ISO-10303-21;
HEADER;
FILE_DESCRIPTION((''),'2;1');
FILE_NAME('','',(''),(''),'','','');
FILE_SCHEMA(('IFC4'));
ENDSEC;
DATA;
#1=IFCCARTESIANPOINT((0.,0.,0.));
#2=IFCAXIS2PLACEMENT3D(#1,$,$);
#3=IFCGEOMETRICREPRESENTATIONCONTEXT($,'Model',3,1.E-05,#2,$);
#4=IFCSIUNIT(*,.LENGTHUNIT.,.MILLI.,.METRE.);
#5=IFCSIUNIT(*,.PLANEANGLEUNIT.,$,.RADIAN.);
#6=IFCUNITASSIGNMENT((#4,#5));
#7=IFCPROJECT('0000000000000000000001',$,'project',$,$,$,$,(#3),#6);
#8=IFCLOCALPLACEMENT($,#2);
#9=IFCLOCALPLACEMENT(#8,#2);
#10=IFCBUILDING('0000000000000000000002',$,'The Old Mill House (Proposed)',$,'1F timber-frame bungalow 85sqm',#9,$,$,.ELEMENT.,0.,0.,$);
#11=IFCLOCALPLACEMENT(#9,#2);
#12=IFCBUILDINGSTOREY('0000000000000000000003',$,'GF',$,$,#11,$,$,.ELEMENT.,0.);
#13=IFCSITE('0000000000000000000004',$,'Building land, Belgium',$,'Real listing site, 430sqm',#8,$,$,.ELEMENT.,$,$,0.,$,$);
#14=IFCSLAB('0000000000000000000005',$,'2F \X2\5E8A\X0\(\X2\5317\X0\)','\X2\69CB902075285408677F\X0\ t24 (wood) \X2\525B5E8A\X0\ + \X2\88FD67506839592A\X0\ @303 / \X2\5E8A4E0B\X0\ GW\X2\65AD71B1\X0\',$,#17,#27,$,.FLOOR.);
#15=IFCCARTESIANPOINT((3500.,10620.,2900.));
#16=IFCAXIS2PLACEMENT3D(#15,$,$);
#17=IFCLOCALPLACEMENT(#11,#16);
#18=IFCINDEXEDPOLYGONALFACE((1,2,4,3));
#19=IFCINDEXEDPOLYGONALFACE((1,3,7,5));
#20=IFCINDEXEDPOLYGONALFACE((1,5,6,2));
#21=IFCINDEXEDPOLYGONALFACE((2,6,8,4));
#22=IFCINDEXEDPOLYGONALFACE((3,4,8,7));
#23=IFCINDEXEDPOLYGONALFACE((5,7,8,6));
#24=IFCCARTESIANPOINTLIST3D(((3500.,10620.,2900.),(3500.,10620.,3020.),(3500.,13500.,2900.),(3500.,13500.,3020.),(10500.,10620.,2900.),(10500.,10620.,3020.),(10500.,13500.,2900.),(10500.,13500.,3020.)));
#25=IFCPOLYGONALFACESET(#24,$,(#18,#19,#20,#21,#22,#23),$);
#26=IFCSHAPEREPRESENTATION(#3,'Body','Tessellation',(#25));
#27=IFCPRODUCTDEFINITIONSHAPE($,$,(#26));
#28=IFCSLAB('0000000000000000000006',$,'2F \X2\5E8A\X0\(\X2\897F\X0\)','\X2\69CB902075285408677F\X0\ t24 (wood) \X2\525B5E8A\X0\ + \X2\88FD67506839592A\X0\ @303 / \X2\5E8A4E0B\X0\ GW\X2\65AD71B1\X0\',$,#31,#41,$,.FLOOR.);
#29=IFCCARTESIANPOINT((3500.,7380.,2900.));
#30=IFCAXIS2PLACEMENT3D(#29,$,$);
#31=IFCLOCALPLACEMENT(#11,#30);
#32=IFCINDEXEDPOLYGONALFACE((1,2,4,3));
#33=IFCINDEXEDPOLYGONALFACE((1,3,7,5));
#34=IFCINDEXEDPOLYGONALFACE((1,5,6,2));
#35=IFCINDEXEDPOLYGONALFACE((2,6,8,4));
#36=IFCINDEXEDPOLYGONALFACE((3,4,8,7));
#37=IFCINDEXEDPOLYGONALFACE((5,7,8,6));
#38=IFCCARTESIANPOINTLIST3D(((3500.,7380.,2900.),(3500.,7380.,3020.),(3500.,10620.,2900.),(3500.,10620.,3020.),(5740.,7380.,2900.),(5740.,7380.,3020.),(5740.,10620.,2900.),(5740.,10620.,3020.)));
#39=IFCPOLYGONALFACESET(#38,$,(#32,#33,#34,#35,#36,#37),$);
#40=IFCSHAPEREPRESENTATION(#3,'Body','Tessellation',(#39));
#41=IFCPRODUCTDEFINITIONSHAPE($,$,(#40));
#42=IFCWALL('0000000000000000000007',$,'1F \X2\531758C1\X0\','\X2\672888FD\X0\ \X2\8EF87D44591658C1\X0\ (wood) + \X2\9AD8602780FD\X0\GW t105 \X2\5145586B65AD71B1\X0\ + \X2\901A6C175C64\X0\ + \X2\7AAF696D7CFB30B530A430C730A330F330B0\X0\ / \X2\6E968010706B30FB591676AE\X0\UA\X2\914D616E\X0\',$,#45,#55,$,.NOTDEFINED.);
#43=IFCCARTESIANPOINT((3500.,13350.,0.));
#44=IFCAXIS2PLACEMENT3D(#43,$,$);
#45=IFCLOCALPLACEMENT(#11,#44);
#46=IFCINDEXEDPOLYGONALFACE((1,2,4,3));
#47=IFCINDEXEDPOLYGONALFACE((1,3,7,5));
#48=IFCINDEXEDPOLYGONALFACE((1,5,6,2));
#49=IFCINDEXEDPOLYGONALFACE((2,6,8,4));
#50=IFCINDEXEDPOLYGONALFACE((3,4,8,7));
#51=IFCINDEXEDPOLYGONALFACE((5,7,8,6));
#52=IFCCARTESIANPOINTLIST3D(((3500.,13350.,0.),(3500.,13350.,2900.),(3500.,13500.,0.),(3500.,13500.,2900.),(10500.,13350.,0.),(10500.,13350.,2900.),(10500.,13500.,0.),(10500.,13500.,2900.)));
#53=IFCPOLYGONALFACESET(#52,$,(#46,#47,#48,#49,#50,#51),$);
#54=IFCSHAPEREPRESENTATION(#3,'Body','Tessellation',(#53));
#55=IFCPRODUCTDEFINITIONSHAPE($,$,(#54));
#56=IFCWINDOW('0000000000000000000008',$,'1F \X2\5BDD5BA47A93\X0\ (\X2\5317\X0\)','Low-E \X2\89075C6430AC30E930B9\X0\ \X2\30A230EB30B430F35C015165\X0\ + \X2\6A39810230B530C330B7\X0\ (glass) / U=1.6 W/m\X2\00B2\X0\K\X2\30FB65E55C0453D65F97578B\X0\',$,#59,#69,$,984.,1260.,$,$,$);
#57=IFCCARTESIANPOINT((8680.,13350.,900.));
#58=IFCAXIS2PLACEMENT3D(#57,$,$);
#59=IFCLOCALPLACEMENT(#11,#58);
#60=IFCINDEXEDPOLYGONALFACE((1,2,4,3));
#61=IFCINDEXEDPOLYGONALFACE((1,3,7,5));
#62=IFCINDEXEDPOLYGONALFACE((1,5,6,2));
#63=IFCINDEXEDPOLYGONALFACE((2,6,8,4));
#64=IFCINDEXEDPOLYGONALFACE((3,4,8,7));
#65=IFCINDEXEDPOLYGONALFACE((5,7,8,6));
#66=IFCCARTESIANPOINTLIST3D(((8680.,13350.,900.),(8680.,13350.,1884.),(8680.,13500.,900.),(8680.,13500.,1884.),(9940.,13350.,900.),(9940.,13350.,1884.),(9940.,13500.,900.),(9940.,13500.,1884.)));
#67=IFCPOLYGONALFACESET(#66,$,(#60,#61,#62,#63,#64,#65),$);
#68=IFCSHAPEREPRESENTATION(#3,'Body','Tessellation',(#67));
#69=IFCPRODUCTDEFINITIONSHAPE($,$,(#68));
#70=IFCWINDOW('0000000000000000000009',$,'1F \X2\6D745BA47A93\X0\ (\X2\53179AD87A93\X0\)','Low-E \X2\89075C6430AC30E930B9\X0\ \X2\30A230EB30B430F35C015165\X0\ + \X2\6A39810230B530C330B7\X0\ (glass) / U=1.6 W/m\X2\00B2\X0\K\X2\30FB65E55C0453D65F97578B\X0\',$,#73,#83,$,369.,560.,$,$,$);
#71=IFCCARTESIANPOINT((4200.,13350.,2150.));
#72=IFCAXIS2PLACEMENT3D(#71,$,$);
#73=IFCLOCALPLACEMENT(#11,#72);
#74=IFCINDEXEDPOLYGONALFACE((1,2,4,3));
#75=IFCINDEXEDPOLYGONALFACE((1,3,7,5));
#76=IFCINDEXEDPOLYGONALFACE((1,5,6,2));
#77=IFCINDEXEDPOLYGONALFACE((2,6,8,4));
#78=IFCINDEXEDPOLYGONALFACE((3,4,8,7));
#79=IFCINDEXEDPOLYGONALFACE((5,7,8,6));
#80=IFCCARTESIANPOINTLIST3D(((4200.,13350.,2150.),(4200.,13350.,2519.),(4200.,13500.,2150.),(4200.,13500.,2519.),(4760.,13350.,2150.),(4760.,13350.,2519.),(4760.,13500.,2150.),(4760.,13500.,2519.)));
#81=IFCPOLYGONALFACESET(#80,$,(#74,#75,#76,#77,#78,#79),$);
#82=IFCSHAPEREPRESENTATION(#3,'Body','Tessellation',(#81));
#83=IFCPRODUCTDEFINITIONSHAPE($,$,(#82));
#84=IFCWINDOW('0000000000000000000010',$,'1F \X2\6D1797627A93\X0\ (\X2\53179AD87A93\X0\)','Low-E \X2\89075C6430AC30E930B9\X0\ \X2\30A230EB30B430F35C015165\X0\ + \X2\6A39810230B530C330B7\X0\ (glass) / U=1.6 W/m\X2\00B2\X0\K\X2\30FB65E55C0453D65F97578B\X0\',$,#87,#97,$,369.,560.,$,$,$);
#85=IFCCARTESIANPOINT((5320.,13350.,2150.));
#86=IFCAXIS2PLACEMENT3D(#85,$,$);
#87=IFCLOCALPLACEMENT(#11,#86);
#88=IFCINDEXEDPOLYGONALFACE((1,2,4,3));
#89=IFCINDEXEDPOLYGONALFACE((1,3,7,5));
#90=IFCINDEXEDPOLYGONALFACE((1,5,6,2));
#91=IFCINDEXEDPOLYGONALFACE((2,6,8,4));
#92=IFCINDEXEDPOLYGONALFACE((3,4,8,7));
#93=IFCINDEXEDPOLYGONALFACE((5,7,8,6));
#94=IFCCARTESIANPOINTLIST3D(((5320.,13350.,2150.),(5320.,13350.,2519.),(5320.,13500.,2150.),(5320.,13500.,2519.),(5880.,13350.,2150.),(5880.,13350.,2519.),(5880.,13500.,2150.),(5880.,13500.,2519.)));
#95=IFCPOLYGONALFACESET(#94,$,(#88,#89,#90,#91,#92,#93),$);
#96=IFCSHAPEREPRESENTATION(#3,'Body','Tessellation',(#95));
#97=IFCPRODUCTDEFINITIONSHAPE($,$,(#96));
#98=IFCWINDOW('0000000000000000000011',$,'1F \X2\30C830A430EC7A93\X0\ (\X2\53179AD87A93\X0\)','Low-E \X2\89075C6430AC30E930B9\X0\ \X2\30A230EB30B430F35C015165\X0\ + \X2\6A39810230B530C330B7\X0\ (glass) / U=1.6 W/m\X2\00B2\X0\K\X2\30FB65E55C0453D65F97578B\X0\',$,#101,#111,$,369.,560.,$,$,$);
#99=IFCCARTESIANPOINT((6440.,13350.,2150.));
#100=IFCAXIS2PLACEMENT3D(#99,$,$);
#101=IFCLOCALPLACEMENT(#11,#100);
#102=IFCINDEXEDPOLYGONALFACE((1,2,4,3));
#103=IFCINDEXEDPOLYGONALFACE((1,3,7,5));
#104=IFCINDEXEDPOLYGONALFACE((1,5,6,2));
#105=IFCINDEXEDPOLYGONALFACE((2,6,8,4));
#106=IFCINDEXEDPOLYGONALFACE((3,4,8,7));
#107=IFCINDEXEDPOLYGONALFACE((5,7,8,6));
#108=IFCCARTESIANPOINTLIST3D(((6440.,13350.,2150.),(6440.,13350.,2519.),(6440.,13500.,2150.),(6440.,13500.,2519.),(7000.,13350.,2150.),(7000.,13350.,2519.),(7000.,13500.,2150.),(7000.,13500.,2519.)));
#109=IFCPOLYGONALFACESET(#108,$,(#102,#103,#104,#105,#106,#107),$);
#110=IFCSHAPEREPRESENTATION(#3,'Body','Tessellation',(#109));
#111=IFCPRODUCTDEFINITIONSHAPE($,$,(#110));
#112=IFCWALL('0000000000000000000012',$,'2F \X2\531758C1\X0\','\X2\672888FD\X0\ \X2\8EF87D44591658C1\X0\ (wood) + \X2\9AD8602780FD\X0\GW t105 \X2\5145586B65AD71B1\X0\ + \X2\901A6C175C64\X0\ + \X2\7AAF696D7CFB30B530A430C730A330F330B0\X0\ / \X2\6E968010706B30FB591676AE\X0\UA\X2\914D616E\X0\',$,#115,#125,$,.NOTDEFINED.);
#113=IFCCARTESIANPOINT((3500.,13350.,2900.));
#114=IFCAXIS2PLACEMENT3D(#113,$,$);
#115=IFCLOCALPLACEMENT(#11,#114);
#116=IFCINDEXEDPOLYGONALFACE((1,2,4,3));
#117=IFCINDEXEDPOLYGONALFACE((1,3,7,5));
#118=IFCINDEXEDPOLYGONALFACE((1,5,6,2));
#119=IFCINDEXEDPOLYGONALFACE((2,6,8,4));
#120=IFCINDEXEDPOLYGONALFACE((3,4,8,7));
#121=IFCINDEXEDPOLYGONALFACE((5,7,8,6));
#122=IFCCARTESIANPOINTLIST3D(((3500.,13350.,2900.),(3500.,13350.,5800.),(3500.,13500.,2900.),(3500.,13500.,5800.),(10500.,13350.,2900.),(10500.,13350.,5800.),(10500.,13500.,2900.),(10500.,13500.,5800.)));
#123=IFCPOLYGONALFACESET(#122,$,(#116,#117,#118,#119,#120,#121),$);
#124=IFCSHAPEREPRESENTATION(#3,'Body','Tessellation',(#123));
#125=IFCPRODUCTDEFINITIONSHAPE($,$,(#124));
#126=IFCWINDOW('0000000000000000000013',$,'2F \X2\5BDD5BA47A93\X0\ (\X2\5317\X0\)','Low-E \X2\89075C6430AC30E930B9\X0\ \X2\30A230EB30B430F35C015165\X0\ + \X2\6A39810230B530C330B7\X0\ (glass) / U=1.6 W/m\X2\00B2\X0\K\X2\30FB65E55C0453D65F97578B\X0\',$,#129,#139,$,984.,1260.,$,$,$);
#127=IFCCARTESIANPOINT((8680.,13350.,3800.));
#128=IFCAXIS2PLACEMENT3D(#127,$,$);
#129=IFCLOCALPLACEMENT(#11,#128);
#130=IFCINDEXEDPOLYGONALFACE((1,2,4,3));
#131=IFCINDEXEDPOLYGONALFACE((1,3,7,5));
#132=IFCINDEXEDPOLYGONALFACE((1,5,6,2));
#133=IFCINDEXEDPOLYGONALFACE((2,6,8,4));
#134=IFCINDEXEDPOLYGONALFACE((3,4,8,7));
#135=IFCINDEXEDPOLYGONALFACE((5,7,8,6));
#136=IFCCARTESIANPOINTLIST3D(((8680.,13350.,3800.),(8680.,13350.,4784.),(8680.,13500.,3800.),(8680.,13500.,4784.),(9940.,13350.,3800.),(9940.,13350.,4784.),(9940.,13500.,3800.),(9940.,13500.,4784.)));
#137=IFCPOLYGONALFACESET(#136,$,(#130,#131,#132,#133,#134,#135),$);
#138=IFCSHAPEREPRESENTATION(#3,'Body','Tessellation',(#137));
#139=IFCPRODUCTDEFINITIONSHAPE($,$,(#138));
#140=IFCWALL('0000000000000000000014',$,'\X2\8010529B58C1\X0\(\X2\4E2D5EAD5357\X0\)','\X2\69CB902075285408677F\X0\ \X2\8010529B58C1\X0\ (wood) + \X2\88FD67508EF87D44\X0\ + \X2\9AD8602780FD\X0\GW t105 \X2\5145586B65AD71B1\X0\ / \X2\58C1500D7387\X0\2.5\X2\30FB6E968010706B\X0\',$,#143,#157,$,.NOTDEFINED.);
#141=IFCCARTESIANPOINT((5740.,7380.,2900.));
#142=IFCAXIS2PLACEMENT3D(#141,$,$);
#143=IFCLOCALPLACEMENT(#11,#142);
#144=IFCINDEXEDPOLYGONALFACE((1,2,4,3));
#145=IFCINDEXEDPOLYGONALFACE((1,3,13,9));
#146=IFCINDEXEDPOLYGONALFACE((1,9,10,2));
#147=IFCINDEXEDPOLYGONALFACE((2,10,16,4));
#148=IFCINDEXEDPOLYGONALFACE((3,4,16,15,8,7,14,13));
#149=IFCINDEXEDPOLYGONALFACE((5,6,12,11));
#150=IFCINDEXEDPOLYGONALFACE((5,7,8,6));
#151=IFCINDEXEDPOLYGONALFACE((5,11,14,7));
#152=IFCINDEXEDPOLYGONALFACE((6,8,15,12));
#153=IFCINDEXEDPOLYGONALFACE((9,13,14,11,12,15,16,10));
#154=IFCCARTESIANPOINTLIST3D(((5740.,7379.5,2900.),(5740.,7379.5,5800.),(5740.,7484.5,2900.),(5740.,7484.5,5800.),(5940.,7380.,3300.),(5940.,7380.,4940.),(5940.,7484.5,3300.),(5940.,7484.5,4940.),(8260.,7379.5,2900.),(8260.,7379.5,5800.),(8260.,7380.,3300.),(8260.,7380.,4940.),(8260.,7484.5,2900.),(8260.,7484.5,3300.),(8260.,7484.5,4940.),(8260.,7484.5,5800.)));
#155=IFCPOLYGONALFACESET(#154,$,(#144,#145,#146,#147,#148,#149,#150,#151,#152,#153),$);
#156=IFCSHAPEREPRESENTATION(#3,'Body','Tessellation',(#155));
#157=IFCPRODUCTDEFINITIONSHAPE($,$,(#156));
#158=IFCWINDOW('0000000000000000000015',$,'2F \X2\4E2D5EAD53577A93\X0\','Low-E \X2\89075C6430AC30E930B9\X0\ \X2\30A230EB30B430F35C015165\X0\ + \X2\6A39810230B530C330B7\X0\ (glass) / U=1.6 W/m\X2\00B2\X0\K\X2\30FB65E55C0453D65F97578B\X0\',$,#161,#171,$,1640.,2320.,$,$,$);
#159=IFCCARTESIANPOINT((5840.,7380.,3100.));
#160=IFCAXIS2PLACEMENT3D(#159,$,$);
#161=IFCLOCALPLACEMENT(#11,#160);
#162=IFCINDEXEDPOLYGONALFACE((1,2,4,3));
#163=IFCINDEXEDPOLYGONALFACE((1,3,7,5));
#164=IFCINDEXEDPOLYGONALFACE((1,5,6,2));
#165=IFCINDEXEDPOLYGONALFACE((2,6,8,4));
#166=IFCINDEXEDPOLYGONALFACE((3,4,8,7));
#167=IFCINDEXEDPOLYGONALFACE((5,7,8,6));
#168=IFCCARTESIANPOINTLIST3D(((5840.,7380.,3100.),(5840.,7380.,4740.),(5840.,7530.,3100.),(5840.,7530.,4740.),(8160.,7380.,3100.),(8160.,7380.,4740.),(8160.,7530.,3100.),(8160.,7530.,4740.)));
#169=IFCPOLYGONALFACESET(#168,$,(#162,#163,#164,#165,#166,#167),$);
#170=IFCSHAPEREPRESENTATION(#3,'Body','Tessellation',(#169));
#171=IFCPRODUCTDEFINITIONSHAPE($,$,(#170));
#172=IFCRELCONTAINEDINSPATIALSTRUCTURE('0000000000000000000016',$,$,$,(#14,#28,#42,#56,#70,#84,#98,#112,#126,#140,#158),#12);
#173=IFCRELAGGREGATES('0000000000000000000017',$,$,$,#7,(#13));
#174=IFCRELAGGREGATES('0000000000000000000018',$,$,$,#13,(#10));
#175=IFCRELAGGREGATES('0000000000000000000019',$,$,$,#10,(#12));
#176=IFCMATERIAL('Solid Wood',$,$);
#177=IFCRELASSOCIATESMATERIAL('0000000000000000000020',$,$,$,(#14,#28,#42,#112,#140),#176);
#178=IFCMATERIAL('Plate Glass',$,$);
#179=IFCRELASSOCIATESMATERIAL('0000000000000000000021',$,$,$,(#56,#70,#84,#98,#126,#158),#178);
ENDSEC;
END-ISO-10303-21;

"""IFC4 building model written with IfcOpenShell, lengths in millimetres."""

from ifc_helpers import new_model, si_unit, frame, frame_2d, origin, place, context, project, spatial, rectangle, extrude, material, element, fill, save


model = new_model("IFC4")

# Units and contexts
model_context = context("Model", 3, precision=1e-05, world=origin())
ifc_project = project(units=[si_unit("LENGTHUNIT", "METRE", prefix="MILLI"), si_unit("PLANEANGLEUNIT", "RADIAN")], contexts=[model_context])

# Site, building, storey
site_placement = place(None, origin())
site = spatial("IfcSite", under=ifc_project, at=site_placement, Name="Building land, Belgium", ObjectType="Real listing site, 430sqm", CompositionType="ELEMENT", RefElevation=0.0)
building_placement = place(site_placement, origin())
building = spatial("IfcBuilding", under=site, at=building_placement, Name="The Old Mill House (Proposed)", ObjectType="1F timber-frame bungalow 85sqm", CompositionType="ELEMENT", ElevationOfRefHeight=0.0, ElevationOfTerrain=0.0)
storey_placement = place(building_placement, origin())
storey = spatial("IfcBuildingStorey", under=building, at=storey_placement, Name="GF", CompositionType="ELEMENT", Elevation=0.0)

# Slabs
ifc_material_1 = material(Name="Solid Wood")
slab_1_placement = place(storey_placement, frame((3500.0, 10620.0, 2900.0)))
element("IfcSlab", 1, at=slab_1_placement, inside=storey, material=ifc_material_1, Name="2F 床(北)", Description="構造用合板 t24 (wood) 剛床 + 製材根太 @303 / 床下 GW断熱", PredefinedType="FLOOR", context=model_context, shape_type="SweptSolid", body=[
    extrude(rectangle(XDim=7000.0, YDim=2880.0, at=frame_2d((3500.0, 1440.0))), frame((3500.0, 10620.0, 2900.0)), (0.0, 0.0, 1.0), 120.0),
])
slab_2_placement = place(storey_placement, frame((3500.0, 7380.0, 2900.0)))
element("IfcSlab", 2, at=slab_2_placement, inside=storey, material=ifc_material_1, Name="2F 床(西)", Description="構造用合板 t24 (wood) 剛床 + 製材根太 @303 / 床下 GW断熱", PredefinedType="FLOOR", context=model_context, shape_type="SweptSolid", body=[
    extrude(rectangle(XDim=2240.0, YDim=3240.0, at=frame_2d((1120.0, 1620.0))), frame((3500.0, 7380.0, 2900.0)), (0.0, 0.0, 1.0), 120.0),
])

# Wall, openings, windows
wall_1_placement = place(storey_placement, frame((3500.0, 13350.0, 0.0)))
wall_1 = element("IfcWall", 3, at=wall_1_placement, inside=storey, material=ifc_material_1, Name="1F 北壁", Description="木製 軸組外壁 (wood) + 高性能GW t105 充填断熱 + 通気層 + 窯業系サイディング / 準耐火・外皮UA配慮", PredefinedType="NOTDEFINED", context=model_context, shape_type="SweptSolid", body=[
    extrude(rectangle(XDim=7000.0, YDim=150.0, at=frame_2d((3500.0, 75.0))), frame((3500.0, 13350.0, 0.0)), (0.0, 0.0, 1.0), 2900.0),
])
opening_1_placement = place(storey_placement, frame((8680.0, 13350.0, 900.0)))
opening_1 = element("IfcOpeningElement", 4, at=opening_1_placement, cuts=wall_1, PredefinedType="NOTDEFINED", context=model_context, shape_type="SweptSolid", body=[
    extrude(rectangle(XDim=1260.0, YDim=150.0, at=frame_2d((630.0, 75.0))), frame((8680.0, 13350.0, 900.0)), (0.0, 0.0, 1.0), 984.0),
])
opening_2_placement = place(storey_placement, frame((4200.0, 13350.0, 2150.0)))
opening_2 = element("IfcOpeningElement", 5, at=opening_2_placement, cuts=wall_1, PredefinedType="NOTDEFINED", context=model_context, shape_type="SweptSolid", body=[
    extrude(rectangle(XDim=560.0, YDim=150.0, at=frame_2d((280.0, 75.0))), frame((4200.0, 13350.0, 2150.0)), (0.0, 0.0, 1.0), 369.0),
])
opening_3_placement = place(storey_placement, frame((5320.0, 13350.0, 2150.0)))
opening_3 = element("IfcOpeningElement", 6, at=opening_3_placement, cuts=wall_1, PredefinedType="NOTDEFINED", context=model_context, shape_type="SweptSolid", body=[
    extrude(rectangle(XDim=560.0, YDim=150.0, at=frame_2d((280.0, 75.0))), frame((5320.0, 13350.0, 2150.0)), (0.0, 0.0, 1.0), 369.0),
])
opening_4_placement = place(storey_placement, frame((6440.0, 13350.0, 2150.0)))
opening_4 = element("IfcOpeningElement", 7, at=opening_4_placement, cuts=wall_1, PredefinedType="NOTDEFINED", context=model_context, shape_type="SweptSolid", body=[
    extrude(rectangle(XDim=560.0, YDim=150.0, at=frame_2d((280.0, 75.0))), frame((6440.0, 13350.0, 2150.0)), (0.0, 0.0, 1.0), 369.0),
])
ifc_material_2 = material(Name="Plate Glass")
window_1_placement = place(storey_placement, frame((8680.0, 13350.0, 900.0)))
window_1 = element("IfcWindow", 8, at=window_1_placement, inside=storey, material=ifc_material_2, Name="1F 寝室窓 (北)", Description="Low-E 複層ガラス アルゴン封入 + 樹脂サッシ (glass) / U=1.6 W/m²K・日射取得型", OverallHeight=984.0, OverallWidth=1260.0, context=model_context, shape_type="SweptSolid", body=[
    extrude(rectangle(XDim=1260.0, YDim=150.0, at=frame_2d((630.0, 75.0))), frame((8680.0, 13350.0, 900.0)), (0.0, 0.0, 1.0), 984.0),
])
fill(opening_1, window_1)
window_2_placement = place(storey_placement, frame((4200.0, 13350.0, 2150.0)))
window_2 = element("IfcWindow", 9, at=window_2_placement, inside=storey, material=ifc_material_2, Name="1F 浴室窓 (北高窓)", Description="Low-E 複層ガラス アルゴン封入 + 樹脂サッシ (glass) / U=1.6 W/m²K・日射取得型", OverallHeight=369.0, OverallWidth=560.0, context=model_context, shape_type="SweptSolid", body=[
    extrude(rectangle(XDim=560.0, YDim=150.0, at=frame_2d((280.0, 75.0))), frame((4200.0, 13350.0, 2150.0)), (0.0, 0.0, 1.0), 369.0),
])
fill(opening_2, window_2)
window_3_placement = place(storey_placement, frame((5320.0, 13350.0, 2150.0)))
window_3 = element("IfcWindow", 10, at=window_3_placement, inside=storey, material=ifc_material_2, Name="1F 洗面窓 (北高窓)", Description="Low-E 複層ガラス アルゴン封入 + 樹脂サッシ (glass) / U=1.6 W/m²K・日射取得型", OverallHeight=369.0, OverallWidth=560.0, context=model_context, shape_type="SweptSolid", body=[
    extrude(rectangle(XDim=560.0, YDim=150.0, at=frame_2d((280.0, 75.0))), frame((5320.0, 13350.0, 2150.0)), (0.0, 0.0, 1.0), 369.0),
])
fill(opening_3, window_3)
window_4_placement = place(storey_placement, frame((6440.0, 13350.0, 2150.0)))
window_4 = element("IfcWindow", 11, at=window_4_placement, inside=storey, material=ifc_material_2, Name="1F トイレ窓 (北高窓)", Description="Low-E 複層ガラス アルゴン封入 + 樹脂サッシ (glass) / U=1.6 W/m²K・日射取得型", OverallHeight=369.0, OverallWidth=560.0, context=model_context, shape_type="SweptSolid", body=[
    extrude(rectangle(XDim=560.0, YDim=150.0, at=frame_2d((280.0, 75.0))), frame((6440.0, 13350.0, 2150.0)), (0.0, 0.0, 1.0), 369.0),
])
fill(opening_4, window_4)

# Walls, openings, windows
wall_2_placement = place(storey_placement, frame((3500.0, 13350.0, 2900.0)))
wall_2 = element("IfcWall", 12, at=wall_2_placement, inside=storey, material=ifc_material_1, Name="2F 北壁", Description="木製 軸組外壁 (wood) + 高性能GW t105 充填断熱 + 通気層 + 窯業系サイディング / 準耐火・外皮UA配慮", PredefinedType="NOTDEFINED", context=model_context, shape_type="SweptSolid", body=[
    extrude(rectangle(XDim=7000.0, YDim=150.0, at=frame_2d((3500.0, 75.0))), frame((3500.0, 13350.0, 2900.0)), (0.0, 0.0, 1.0), 2900.0),
])
opening_5_placement = place(storey_placement, frame((8680.0, 13350.0, 3800.0)))
opening_5 = element("IfcOpeningElement", 13, at=opening_5_placement, cuts=wall_2, PredefinedType="NOTDEFINED", context=model_context, shape_type="SweptSolid", body=[
    extrude(rectangle(XDim=1260.0, YDim=150.0, at=frame_2d((630.0, 75.0))), frame((8680.0, 13350.0, 3800.0)), (0.0, 0.0, 1.0), 984.0),
])
window_5_placement = place(storey_placement, frame((8680.0, 13350.0, 3800.0)))
window_5 = element("IfcWindow", 14, at=window_5_placement, inside=storey, material=ifc_material_2, Name="2F 寝室窓 (北)", Description="Low-E 複層ガラス アルゴン封入 + 樹脂サッシ (glass) / U=1.6 W/m²K・日射取得型", OverallHeight=984.0, OverallWidth=1260.0, context=model_context, shape_type="SweptSolid", body=[
    extrude(rectangle(XDim=1260.0, YDim=150.0, at=frame_2d((630.0, 75.0))), frame((8680.0, 13350.0, 3800.0)), (0.0, 0.0, 1.0), 984.0),
])
fill(opening_5, window_5)
wall_3_placement = place(storey_placement, frame((5740.0, 7380.0, 2900.0)))
wall_3 = element("IfcWall", 15, at=wall_3_placement, inside=storey, material=ifc_material_1, Name="耐力壁(中庭南)", Description="構造用合板 耐力壁 (wood) + 製材軸組 + 高性能GW t105 充填断熱 / 壁倍率2.5・準耐火", PredefinedType="NOTDEFINED", context=model_context, shape_type="SweptSolid", body=[
    extrude(rectangle(XDim=2520.0, YDim=105.0, at=frame_2d((1260.0, 52.0))), frame((5740.0, 7380.0, 2900.0)), (0.0, 0.0, 1.0), 2900.0),
])
opening_6_placement = place(storey_placement, frame((5840.0, 7380.0, 3100.0)))
opening_6 = element("IfcOpeningElement", 16, at=opening_6_placement, cuts=wall_3, PredefinedType="NOTDEFINED", context=model_context, shape_type="SweptSolid", body=[
    extrude(rectangle(XDim=2320.0, YDim=150.0, at=frame_2d((1160.0, 75.0))), frame((5840.0, 7380.0, 3100.0)), (0.0, 0.0, 1.0), 1640.0),
])
window_6_placement = place(storey_placement, frame((5840.0, 7380.0, 3100.0)))
window_6 = element("IfcWindow", 17, at=window_6_placement, inside=storey, material=ifc_material_2, Name="2F 中庭南窓", Description="Low-E 複層ガラス アルゴン封入 + 樹脂サッシ (glass) / U=1.6 W/m²K・日射取得型", OverallHeight=1640.0, OverallWidth=2320.0, context=model_context, shape_type="SweptSolid", body=[
    extrude(rectangle(XDim=2320.0, YDim=150.0, at=frame_2d((1160.0, 75.0))), frame((5840.0, 7380.0, 3100.0)), (0.0, 0.0, 1.0), 1640.0),
])
fill(opening_6, window_6)

save(model, "model.ifc")
